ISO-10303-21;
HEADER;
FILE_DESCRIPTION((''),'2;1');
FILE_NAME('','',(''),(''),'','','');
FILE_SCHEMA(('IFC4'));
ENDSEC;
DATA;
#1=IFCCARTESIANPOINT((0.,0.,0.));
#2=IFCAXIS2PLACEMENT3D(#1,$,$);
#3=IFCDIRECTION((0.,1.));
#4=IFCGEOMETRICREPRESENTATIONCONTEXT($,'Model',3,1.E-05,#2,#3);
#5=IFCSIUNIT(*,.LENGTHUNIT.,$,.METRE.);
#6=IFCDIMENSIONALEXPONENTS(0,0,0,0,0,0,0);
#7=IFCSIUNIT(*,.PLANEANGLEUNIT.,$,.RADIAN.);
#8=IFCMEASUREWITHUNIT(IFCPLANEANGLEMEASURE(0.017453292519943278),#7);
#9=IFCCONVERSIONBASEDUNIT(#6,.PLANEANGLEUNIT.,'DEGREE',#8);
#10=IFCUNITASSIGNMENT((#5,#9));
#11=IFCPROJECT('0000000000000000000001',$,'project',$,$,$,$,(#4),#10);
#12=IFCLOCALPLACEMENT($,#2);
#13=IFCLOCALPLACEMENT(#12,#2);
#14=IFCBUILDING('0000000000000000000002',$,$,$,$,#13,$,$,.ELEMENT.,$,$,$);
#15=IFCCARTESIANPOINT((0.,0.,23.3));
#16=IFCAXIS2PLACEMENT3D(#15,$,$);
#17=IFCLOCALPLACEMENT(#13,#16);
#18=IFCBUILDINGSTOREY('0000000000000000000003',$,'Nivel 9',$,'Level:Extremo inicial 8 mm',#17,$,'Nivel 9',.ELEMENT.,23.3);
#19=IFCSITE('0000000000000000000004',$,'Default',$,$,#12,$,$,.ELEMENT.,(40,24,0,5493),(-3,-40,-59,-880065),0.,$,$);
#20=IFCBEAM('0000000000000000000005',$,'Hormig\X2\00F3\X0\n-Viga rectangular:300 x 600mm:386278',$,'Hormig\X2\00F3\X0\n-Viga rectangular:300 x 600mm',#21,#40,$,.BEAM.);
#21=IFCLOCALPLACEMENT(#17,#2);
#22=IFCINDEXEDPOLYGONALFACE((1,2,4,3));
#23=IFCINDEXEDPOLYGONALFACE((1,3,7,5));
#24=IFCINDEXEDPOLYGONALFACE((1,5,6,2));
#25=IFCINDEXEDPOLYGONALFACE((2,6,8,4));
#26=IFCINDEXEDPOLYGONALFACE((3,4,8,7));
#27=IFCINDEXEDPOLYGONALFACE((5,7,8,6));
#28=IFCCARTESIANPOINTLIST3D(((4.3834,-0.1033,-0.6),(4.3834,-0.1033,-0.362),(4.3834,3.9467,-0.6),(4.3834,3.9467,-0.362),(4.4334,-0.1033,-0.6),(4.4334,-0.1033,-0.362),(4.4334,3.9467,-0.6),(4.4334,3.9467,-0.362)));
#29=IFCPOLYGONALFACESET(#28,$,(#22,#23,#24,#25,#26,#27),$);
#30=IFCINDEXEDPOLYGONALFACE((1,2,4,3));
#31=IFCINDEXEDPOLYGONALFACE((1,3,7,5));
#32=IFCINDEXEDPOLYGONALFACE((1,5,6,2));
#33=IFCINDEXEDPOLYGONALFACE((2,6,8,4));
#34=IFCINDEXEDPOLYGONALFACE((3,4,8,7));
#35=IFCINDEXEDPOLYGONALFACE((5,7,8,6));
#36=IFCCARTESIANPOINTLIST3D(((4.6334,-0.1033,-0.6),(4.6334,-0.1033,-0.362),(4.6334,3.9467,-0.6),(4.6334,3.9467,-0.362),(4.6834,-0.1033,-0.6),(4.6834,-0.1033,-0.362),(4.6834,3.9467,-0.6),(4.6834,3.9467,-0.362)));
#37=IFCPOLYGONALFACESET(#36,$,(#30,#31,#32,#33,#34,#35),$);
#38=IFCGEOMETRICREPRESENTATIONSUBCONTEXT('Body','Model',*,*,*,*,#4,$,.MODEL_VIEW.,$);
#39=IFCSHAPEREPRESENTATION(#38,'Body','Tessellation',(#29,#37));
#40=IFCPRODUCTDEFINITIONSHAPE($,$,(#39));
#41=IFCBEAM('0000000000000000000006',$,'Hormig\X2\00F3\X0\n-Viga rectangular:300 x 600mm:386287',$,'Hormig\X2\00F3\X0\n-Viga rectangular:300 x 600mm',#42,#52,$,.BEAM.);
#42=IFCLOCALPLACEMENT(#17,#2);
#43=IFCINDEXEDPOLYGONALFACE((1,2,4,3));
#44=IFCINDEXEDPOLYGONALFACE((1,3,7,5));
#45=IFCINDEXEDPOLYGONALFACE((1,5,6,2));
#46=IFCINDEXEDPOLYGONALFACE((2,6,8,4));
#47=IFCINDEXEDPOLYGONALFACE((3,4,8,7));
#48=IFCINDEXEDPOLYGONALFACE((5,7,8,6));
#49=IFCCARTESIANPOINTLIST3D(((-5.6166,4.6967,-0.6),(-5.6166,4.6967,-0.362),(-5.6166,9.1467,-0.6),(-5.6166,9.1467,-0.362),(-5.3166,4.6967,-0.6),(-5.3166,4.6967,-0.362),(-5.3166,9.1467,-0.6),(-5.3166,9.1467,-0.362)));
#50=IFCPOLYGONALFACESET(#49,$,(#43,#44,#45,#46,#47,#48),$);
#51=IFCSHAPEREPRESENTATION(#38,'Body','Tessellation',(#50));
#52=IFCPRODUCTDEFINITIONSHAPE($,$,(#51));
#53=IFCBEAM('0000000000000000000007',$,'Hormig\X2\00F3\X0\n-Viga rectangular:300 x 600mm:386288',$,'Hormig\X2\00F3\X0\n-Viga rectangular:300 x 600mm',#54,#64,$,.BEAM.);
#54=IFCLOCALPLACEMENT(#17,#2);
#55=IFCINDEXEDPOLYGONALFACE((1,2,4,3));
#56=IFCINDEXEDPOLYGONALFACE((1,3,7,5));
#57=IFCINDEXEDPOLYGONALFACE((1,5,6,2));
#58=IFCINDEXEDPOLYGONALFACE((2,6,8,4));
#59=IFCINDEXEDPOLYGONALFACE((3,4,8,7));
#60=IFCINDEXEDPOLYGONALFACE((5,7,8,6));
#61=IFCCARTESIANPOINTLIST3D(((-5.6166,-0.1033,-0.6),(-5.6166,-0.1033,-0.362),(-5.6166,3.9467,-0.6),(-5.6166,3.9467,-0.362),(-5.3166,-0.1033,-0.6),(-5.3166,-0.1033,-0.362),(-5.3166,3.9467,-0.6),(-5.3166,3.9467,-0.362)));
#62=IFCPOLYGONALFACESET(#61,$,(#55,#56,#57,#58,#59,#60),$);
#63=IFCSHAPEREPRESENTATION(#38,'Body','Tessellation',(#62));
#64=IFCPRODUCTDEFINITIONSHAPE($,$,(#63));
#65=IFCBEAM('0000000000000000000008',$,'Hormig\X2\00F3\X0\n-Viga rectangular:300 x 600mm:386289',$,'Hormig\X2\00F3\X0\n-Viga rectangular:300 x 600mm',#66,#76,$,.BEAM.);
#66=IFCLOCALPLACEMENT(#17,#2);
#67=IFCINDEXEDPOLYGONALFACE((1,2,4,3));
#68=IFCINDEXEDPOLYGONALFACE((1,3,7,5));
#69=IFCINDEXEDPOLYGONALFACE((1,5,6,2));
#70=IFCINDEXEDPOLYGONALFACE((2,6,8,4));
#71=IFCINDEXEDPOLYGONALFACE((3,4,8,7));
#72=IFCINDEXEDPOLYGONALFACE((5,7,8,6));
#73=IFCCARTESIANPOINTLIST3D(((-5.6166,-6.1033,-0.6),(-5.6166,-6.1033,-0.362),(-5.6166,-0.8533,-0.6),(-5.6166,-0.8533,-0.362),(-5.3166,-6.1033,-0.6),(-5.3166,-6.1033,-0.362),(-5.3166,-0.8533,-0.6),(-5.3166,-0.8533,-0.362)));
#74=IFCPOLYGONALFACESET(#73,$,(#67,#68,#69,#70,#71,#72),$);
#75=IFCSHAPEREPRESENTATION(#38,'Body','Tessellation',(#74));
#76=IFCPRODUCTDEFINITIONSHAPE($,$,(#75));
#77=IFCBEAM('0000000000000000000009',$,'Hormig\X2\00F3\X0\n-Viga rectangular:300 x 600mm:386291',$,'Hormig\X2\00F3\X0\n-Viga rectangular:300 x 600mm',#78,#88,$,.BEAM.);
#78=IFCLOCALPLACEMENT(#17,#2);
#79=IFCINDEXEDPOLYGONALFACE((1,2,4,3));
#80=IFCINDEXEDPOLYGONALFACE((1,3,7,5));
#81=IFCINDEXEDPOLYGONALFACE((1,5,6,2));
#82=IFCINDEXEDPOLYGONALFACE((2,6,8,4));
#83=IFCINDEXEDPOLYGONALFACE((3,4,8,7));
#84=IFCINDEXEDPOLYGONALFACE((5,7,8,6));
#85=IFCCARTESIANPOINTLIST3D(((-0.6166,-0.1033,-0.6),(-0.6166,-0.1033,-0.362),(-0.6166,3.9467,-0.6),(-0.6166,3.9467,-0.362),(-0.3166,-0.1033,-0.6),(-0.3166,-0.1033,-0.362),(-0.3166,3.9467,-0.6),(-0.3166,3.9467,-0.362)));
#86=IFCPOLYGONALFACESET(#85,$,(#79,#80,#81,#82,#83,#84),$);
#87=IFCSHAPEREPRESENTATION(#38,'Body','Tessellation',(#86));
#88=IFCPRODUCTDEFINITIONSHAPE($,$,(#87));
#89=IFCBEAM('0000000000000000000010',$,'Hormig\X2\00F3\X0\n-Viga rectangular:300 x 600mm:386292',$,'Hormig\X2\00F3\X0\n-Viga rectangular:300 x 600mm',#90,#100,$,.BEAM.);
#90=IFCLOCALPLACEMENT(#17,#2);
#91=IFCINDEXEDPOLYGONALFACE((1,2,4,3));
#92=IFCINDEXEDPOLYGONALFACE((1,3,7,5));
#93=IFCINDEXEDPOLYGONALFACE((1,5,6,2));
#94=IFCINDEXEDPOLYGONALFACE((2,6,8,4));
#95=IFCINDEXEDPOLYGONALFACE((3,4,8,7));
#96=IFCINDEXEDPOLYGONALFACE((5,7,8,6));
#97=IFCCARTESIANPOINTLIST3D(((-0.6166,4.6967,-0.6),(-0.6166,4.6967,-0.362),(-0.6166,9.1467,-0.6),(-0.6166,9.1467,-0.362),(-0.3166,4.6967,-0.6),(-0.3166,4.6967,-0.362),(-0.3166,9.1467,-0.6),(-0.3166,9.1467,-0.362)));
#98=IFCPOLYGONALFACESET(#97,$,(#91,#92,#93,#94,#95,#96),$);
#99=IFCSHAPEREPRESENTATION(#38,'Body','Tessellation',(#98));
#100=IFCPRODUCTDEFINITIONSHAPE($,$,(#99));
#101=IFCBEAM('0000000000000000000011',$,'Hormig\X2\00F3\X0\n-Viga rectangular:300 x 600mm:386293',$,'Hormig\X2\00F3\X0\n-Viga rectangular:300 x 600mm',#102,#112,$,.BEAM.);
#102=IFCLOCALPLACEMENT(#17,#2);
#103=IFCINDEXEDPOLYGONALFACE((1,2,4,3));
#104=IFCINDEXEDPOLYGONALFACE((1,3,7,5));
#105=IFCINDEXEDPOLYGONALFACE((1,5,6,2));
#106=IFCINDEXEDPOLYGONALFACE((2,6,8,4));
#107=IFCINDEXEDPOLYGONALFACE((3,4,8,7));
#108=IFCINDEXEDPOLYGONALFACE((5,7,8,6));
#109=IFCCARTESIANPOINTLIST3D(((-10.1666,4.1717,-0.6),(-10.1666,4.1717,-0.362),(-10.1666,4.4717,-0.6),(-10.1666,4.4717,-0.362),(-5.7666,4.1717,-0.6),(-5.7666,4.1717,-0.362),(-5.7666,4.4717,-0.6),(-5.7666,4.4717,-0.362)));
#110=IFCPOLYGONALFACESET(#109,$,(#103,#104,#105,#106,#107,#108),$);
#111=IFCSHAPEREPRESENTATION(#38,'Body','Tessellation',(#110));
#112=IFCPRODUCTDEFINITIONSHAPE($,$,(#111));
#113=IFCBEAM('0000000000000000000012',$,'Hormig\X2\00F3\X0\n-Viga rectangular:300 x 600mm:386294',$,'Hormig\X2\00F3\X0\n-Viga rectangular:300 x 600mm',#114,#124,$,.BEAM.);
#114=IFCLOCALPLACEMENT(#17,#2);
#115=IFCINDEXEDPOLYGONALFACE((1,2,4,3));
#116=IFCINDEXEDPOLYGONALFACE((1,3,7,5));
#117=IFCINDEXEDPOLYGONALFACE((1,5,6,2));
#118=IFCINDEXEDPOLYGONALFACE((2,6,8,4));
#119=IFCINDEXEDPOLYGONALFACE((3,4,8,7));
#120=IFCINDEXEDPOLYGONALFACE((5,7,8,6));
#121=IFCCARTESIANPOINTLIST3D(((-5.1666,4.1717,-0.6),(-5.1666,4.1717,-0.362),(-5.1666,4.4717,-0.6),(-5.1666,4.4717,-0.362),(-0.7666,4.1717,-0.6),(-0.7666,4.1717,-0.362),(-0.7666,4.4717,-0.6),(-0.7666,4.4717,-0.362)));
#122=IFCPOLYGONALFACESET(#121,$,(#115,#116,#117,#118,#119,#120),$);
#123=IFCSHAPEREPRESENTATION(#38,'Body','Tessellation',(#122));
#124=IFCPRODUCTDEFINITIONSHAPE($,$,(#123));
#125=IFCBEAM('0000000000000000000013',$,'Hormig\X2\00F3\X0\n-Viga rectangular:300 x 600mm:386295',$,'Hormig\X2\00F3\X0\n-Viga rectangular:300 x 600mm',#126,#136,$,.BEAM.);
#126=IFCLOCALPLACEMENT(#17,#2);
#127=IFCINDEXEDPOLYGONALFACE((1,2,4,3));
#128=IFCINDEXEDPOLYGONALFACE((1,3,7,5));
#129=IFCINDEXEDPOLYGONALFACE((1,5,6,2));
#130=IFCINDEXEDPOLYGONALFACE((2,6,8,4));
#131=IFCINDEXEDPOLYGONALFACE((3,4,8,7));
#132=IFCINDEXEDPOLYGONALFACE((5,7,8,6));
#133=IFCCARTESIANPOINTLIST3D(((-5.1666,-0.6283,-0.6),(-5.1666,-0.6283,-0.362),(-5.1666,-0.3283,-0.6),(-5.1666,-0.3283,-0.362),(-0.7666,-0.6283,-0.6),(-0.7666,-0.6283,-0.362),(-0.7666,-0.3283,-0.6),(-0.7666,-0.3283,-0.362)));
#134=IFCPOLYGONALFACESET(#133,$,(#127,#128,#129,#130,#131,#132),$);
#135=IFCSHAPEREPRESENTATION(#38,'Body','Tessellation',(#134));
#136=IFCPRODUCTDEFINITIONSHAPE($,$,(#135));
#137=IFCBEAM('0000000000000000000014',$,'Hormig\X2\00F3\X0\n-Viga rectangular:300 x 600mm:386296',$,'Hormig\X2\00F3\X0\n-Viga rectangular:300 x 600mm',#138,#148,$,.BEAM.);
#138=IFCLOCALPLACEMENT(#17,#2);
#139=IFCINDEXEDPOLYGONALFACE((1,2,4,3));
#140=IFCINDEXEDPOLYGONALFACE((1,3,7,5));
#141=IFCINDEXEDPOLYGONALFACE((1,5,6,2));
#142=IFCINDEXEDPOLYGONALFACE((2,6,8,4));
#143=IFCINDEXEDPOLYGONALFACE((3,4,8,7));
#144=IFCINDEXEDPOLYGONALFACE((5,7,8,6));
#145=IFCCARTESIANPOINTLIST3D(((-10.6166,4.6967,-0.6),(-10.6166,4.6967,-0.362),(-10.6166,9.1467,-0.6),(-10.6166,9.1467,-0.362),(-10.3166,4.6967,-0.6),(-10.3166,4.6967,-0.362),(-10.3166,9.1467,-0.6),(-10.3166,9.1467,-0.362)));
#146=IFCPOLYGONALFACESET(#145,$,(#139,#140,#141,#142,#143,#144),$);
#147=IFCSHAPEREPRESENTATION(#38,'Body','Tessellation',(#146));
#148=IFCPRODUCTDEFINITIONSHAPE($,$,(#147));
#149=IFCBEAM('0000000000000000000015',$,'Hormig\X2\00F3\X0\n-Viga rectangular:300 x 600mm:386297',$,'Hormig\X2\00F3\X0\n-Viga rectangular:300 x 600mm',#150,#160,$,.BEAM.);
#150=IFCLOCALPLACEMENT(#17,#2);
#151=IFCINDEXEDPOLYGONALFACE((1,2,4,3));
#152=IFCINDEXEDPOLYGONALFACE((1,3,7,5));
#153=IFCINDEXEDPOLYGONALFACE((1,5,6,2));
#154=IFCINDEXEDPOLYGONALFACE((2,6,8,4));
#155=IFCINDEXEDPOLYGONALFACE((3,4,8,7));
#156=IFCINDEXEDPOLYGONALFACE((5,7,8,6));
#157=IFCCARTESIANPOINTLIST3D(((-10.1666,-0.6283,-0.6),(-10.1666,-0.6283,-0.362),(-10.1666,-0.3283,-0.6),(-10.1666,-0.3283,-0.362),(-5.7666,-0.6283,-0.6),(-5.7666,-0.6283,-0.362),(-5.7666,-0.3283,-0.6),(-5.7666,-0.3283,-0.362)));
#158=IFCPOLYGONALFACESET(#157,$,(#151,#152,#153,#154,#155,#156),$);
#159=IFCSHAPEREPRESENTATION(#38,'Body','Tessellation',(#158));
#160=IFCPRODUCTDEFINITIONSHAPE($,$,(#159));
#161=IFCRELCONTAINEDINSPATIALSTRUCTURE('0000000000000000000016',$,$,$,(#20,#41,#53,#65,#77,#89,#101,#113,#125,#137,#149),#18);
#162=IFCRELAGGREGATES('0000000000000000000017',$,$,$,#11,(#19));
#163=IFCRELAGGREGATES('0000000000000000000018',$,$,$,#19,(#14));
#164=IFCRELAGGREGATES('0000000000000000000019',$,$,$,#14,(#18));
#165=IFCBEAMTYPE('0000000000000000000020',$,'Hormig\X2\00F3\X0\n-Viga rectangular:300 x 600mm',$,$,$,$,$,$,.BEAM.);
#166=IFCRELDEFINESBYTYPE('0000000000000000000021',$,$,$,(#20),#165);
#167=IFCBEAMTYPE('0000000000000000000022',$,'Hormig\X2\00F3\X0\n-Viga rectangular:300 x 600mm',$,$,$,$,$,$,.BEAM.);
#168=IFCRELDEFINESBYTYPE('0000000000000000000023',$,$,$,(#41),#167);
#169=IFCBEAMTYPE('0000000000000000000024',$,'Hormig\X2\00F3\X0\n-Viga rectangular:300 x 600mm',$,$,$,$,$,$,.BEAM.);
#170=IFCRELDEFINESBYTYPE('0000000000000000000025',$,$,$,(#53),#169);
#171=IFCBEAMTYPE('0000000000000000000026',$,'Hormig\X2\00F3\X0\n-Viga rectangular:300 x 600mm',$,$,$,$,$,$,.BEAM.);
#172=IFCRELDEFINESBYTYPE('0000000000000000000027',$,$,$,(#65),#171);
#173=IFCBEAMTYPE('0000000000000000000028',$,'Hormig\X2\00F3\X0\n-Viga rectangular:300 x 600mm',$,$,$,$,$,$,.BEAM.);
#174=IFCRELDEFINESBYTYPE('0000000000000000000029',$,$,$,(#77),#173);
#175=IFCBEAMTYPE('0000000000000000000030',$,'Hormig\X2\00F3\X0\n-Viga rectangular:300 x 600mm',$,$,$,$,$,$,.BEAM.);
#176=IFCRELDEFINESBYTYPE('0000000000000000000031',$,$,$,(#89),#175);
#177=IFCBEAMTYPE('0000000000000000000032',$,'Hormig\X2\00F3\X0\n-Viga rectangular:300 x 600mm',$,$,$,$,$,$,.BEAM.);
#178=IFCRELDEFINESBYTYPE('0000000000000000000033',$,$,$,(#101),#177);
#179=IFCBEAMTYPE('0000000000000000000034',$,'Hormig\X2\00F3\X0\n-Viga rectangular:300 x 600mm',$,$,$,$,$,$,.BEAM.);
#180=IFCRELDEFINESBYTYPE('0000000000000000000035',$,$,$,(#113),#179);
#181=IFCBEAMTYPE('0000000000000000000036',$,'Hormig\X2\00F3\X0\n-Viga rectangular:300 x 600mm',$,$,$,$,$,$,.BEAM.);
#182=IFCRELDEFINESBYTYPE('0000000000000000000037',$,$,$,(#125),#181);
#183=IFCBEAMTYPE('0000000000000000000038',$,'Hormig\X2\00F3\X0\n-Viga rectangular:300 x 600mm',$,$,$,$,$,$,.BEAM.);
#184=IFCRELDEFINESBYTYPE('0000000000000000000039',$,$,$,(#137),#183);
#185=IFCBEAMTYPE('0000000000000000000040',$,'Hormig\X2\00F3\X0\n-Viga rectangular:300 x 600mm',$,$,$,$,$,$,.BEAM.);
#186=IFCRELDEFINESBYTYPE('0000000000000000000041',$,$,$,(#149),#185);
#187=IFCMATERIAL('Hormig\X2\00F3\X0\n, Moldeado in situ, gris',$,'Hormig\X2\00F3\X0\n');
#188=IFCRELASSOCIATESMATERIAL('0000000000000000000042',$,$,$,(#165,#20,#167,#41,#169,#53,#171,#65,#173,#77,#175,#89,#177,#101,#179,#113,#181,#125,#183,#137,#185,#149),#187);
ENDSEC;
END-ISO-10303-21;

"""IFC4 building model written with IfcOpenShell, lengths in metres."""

from ifc_helpers import new_model, entity, si_unit, converted_unit, direction, frame, origin, place, context, subcontext, project, spatial, indexed_curve, outline, extrude, source, transform, mapped, material, type_object, type_shapes, element, save


model = new_model("IFC4")

# Units and contexts
model_context = context("Model", 3, precision=1e-05, world=origin(), true_north=direction((0.0, 1.0)))
body_context = subcontext(model_context, "Body", "Model", "MODEL_VIEW")
ifc_project = project(units=[si_unit("LENGTHUNIT", "METRE"), converted_unit("PLANEANGLEUNIT", "DEGREE", entity("IfcPlaneAngleMeasure", 0.017453292519943278), si_unit("PLANEANGLEUNIT", "RADIAN"), dimensions=[0, 0, 0, 0, 0, 0, 0])], contexts=[model_context])

# Site, building, storey
site_placement = place(None, origin())
site = spatial("IfcSite", under=ifc_project, at=site_placement, Name="Default", CompositionType="ELEMENT", RefLatitude=(40, 24, 0, 5493), RefLongitude=(-3, -40, -59, -880065), RefElevation=0.0)
building_placement = place(site_placement, origin())
building = spatial("IfcBuilding", under=site, at=building_placement, CompositionType="ELEMENT")
storey_placement = place(building_placement, frame((0.0, 0.0, 23.3)))
storey = spatial("IfcBuildingStorey", under=building, at=storey_placement, Name="Nivel 9", ObjectType="Level:Extremo inicial 8 mm", LongName="Nivel 9", CompositionType="ELEMENT", Elevation=23.3)

# Shared definitions
ifc_material_1 = material(Name="Hormigón, Moldeado in situ, gris", Category="Hormigón")

# Beams
beam_type_1 = type_object("IfcBeamType", Name="Hormigón-Viga rectangular:300 x 600mm", PredefinedType="BEAM", material=ifc_material_1)
shared_shape_1 = source(origin(), body_context, "Body", "SweptSolid", [
    extrude(outline(indexed_curve([(-0.025, -0.119), (0.025, -0.119), (0.025, 0.119), (-0.025, 0.119), (-0.025, -0.119)], self_intersect=False)), frame((4.4084, 3.9467, 22.819), z_axis=(0.0, -1.0, 0.0), x_axis=(-1.0, 0.0, 0.0)), (0.0, 0.0, 1.0), 4.05),
    extrude(outline(indexed_curve([(-0.025, -0.119), (0.025, -0.119), (0.025, 0.119), (-0.025, 0.119), (-0.025, -0.119)], self_intersect=False)), frame((4.6584, 3.9467, 22.819), z_axis=(0.0, -1.0, 0.0), x_axis=(-1.0, 0.0, 0.0)), (0.0, 0.0, 1.0), 4.05),
])
type_shapes(beam_type_1, [shared_shape_1])
beam_1_placement = place(storey_placement, frame((0.0, 0.0, -23.3)))
element("IfcBeam", 1, at=beam_1_placement, inside=storey, type_object=beam_type_1, material=ifc_material_1, Name="Hormigón-Viga rectangular:300 x 600mm:386278", ObjectType="Hormigón-Viga rectangular:300 x 600mm", PredefinedType="BEAM", context=body_context, shape_type="MappedRepresentation", body=[
    mapped(shared_shape_1, transform((0.0, 0.0, 0.0), scale=1.0)),
])
beam_type_2 = type_object("IfcBeamType", Name="Hormigón-Viga rectangular:300 x 600mm", PredefinedType="BEAM", material=ifc_material_1)
shared_shape_2 = source(origin(), body_context, "Body", "SweptSolid", [
    extrude(outline(indexed_curve([(-0.15, -0.119), (0.15, -0.119), (0.15, 0.119), (-0.15, 0.119), (-0.15, -0.119)], self_intersect=False)), frame((-5.4666, 9.1467, 22.819), z_axis=(0.0, -1.0, 0.0), x_axis=(-1.0, 0.0, 0.0)), (0.0, 0.0, 1.0), 4.45),
])
type_shapes(beam_type_2, [shared_shape_2])
beam_2_placement = place(storey_placement, frame((0.0, 0.0, -23.3)))
element("IfcBeam", 2, at=beam_2_placement, inside=storey, type_object=beam_type_2, material=ifc_material_1, Name="Hormigón-Viga rectangular:300 x 600mm:386287", ObjectType="Hormigón-Viga rectangular:300 x 600mm", PredefinedType="BEAM", context=body_context, shape_type="MappedRepresentation", body=[
    mapped(shared_shape_2, transform((0.0, 0.0, 0.0), scale=1.0)),
])
beam_type_3 = type_object("IfcBeamType", Name="Hormigón-Viga rectangular:300 x 600mm", PredefinedType="BEAM", material=ifc_material_1)
shared_shape_3 = source(origin(), body_context, "Body", "SweptSolid", [
    extrude(outline(indexed_curve([(-0.15, -0.119), (0.15, -0.119), (0.15, 0.119), (-0.15, 0.119), (-0.15, -0.119)], self_intersect=False)), frame((-5.4666, 3.9467, 22.819), z_axis=(0.0, -1.0, 0.0), x_axis=(-1.0, 0.0, 0.0)), (0.0, 0.0, 1.0), 4.05),
])
type_shapes(beam_type_3, [shared_shape_3])
beam_3_placement = place(storey_placement, frame((0.0, 0.0, -23.3)))
element("IfcBeam", 3, at=beam_3_placement, inside=storey, type_object=beam_type_3, material=ifc_material_1, Name="Hormigón-Viga rectangular:300 x 600mm:386288", ObjectType="Hormigón-Viga rectangular:300 x 600mm", PredefinedType="BEAM", context=body_context, shape_type="MappedRepresentation", body=[
    mapped(shared_shape_3, transform((0.0, 0.0, 0.0), scale=1.0)),
])
beam_type_4 = type_object("IfcBeamType", Name="Hormigón-Viga rectangular:300 x 600mm", PredefinedType="BEAM", material=ifc_material_1)
shared_shape_4 = source(origin(), body_context, "Body", "SweptSolid", [
    extrude(outline(indexed_curve([(-0.15, -0.119), (0.15, -0.119), (0.15, 0.119), (-0.15, 0.119), (-0.15, -0.119)], self_intersect=False)), frame((-5.4666, -6.1033, 22.819), z_axis=(0.0, 1.0, 0.0), x_axis=(-1.0, 0.0, 0.0)), (0.0, 0.0, 1.0), 5.25),
])
type_shapes(beam_type_4, [shared_shape_4])
beam_4_placement = place(storey_placement, frame((0.0, 0.0, -23.3)))
element("IfcBeam", 4, at=beam_4_placement, inside=storey, type_object=beam_type_4, material=ifc_material_1, Name="Hormigón-Viga rectangular:300 x 600mm:386289", ObjectType="Hormigón-Viga rectangular:300 x 600mm", PredefinedType="BEAM", context=body_context, shape_type="MappedRepresentation", body=[
    mapped(shared_shape_4, transform((0.0, 0.0, 0.0), scale=1.0)),
])
beam_type_5 = type_object("IfcBeamType", Name="Hormigón-Viga rectangular:300 x 600mm", PredefinedType="BEAM", material=ifc_material_1)
shared_shape_5 = source(origin(), body_context, "Body", "SweptSolid", [
    extrude(outline(indexed_curve([(-0.15, -0.119), (0.15, -0.119), (0.15, 0.119), (-0.15, 0.119), (-0.15, -0.119)], self_intersect=False)), frame((-0.4666, -0.1033, 22.819), z_axis=(0.0, 1.0, 0.0), x_axis=(-1.0, 0.0, 0.0)), (0.0, 0.0, 1.0), 4.05),
])
type_shapes(beam_type_5, [shared_shape_5])
beam_5_placement = place(storey_placement, frame((0.0, 0.0, -23.3)))
element("IfcBeam", 5, at=beam_5_placement, inside=storey, type_object=beam_type_5, material=ifc_material_1, Name="Hormigón-Viga rectangular:300 x 600mm:386291", ObjectType="Hormigón-Viga rectangular:300 x 600mm", PredefinedType="BEAM", context=body_context, shape_type="MappedRepresentation", body=[
    mapped(shared_shape_5, transform((0.0, 0.0, 0.0), scale=1.0)),
])
beam_type_6 = type_object("IfcBeamType", Name="Hormigón-Viga rectangular:300 x 600mm", PredefinedType="BEAM", material=ifc_material_1)
shared_shape_6 = source(origin(), body_context, "Body", "SweptSolid", [
    extrude(outline(indexed_curve([(-0.15, -0.119), (0.15, -0.119), (0.15, 0.119), (-0.15, 0.119), (-0.15, -0.119)], self_intersect=False)), frame((-0.4666, 9.1467, 22.819), z_axis=(0.0, -1.0, 0.0), x_axis=(-1.0, 0.0, 0.0)), (0.0, 0.0, 1.0), 4.45),
])
type_shapes(beam_type_6, [shared_shape_6])
beam_6_placement = place(storey_placement, frame((0.0, 0.0, -23.3)))
element("IfcBeam", 6, at=beam_6_placement, inside=storey, type_object=beam_type_6, material=ifc_material_1, Name="Hormigón-Viga rectangular:300 x 600mm:386292", ObjectType="Hormigón-Viga rectangular:300 x 600mm", PredefinedType="BEAM", context=body_context, shape_type="MappedRepresentation", body=[
    mapped(shared_shape_6, transform((0.0, 0.0, 0.0), scale=1.0)),
])
beam_type_7 = type_object("IfcBeamType", Name="Hormigón-Viga rectangular:300 x 600mm", PredefinedType="BEAM", material=ifc_material_1)
shared_shape_7 = source(origin(), body_context, "Body", "SweptSolid", [
    extrude(outline(indexed_curve([(-0.119, -0.15), (0.119, -0.15), (0.119, 0.15), (-0.119, 0.15), (-0.119, -0.15)], self_intersect=False)), frame((-10.1666, 4.3217, 22.819), z_axis=(1.0, 0.0, 0.0), x_axis=(0.0, 0.0, -1.0)), (0.0, 0.0, 1.0), 4.4),
])
type_shapes(beam_type_7, [shared_shape_7])
beam_7_placement = place(storey_placement, frame((0.0, 0.0, -23.3)))
element("IfcBeam", 7, at=beam_7_placement, inside=storey, type_object=beam_type_7, material=ifc_material_1, Name="Hormigón-Viga rectangular:300 x 600mm:386293", ObjectType="Hormigón-Viga rectangular:300 x 600mm", PredefinedType="BEAM", context=body_context, shape_type="MappedRepresentation", body=[
    mapped(shared_shape_7, transform((0.0, 0.0, 0.0), scale=1.0)),
])
beam_type_8 = type_object("IfcBeamType", Name="Hormigón-Viga rectangular:300 x 600mm", PredefinedType="BEAM", material=ifc_material_1)
shared_shape_8 = source(origin(), body_context, "Body", "SweptSolid", [
    extrude(outline(indexed_curve([(-0.119, -0.15), (0.119, -0.15), (0.119, 0.15), (-0.119, 0.15), (-0.119, -0.15)], self_intersect=False)), frame((-5.1666, 4.3217, 22.819), z_axis=(1.0, 0.0, 0.0), x_axis=(0.0, 0.0, -1.0)), (0.0, 0.0, 1.0), 4.4),
])
type_shapes(beam_type_8, [shared_shape_8])
beam_8_placement = place(storey_placement, frame((0.0, 0.0, -23.3)))
element("IfcBeam", 8, at=beam_8_placement, inside=storey, type_object=beam_type_8, material=ifc_material_1, Name="Hormigón-Viga rectangular:300 x 600mm:386294", ObjectType="Hormigón-Viga rectangular:300 x 600mm", PredefinedType="BEAM", context=body_context, shape_type="MappedRepresentation", body=[
    mapped(shared_shape_8, transform((0.0, 0.0, 0.0), scale=1.0)),
])
beam_type_9 = type_object("IfcBeamType", Name="Hormigón-Viga rectangular:300 x 600mm", PredefinedType="BEAM", material=ifc_material_1)
shared_shape_9 = source(origin(), body_context, "Body", "SweptSolid", [
    extrude(outline(indexed_curve([(-0.119, -0.15), (0.119, -0.15), (0.119, 0.15), (-0.119, 0.15), (-0.119, -0.15)], self_intersect=False)), frame((-0.7666, -0.4783, 22.819), z_axis=(-1.0, 0.0, 0.0), x_axis=(0.0, 0.0, -1.0)), (0.0, 0.0, 1.0), 4.4),
])
type_shapes(beam_type_9, [shared_shape_9])
beam_9_placement = place(storey_placement, frame((0.0, 0.0, -23.3)))
element("IfcBeam", 9, at=beam_9_placement, inside=storey, type_object=beam_type_9, material=ifc_material_1, Name="Hormigón-Viga rectangular:300 x 600mm:386295", ObjectType="Hormigón-Viga rectangular:300 x 600mm", PredefinedType="BEAM", context=body_context, shape_type="MappedRepresentation", body=[
    mapped(shared_shape_9, transform((0.0, 0.0, 0.0), scale=1.0)),
])
beam_type_10 = type_object("IfcBeamType", Name="Hormigón-Viga rectangular:300 x 600mm", PredefinedType="BEAM", material=ifc_material_1)
shared_shape_10 = source(origin(), body_context, "Body", "SweptSolid", [
    extrude(outline(indexed_curve([(-0.15, -0.119), (0.15, -0.119), (0.15, 0.119), (-0.15, 0.119), (-0.15, -0.119)], self_intersect=False)), frame((-10.4666, 4.6967, 22.819), z_axis=(0.0, 1.0, 0.0), x_axis=(-1.0, 0.0, 0.0)), (0.0, 0.0, 1.0), 4.45),
])
type_shapes(beam_type_10, [shared_shape_10])
beam_10_placement = place(storey_placement, frame((0.0, 0.0, -23.3)))
element("IfcBeam", 10, at=beam_10_placement, inside=storey, type_object=beam_type_10, material=ifc_material_1, Name="Hormigón-Viga rectangular:300 x 600mm:386296", ObjectType="Hormigón-Viga rectangular:300 x 600mm", PredefinedType="BEAM", context=body_context, shape_type="MappedRepresentation", body=[
    mapped(shared_shape_10, transform((0.0, 0.0, 0.0), scale=1.0)),
])
beam_type_11 = type_object("IfcBeamType", Name="Hormigón-Viga rectangular:300 x 600mm", PredefinedType="BEAM", material=ifc_material_1)
shared_shape_11 = source(origin(), body_context, "Body", "SweptSolid", [
    extrude(outline(indexed_curve([(-0.119, -0.15), (0.119, -0.15), (0.119, 0.15), (-0.119, 0.15), (-0.119, -0.15)], self_intersect=False)), frame((-10.1666, -0.4783, 22.819), z_axis=(1.0, 0.0, 0.0), x_axis=(0.0, 0.0, -1.0)), (0.0, 0.0, 1.0), 4.4),
])
type_shapes(beam_type_11, [shared_shape_11])
beam_11_placement = place(storey_placement, frame((0.0, 0.0, -23.3)))
element("IfcBeam", 11, at=beam_11_placement, inside=storey, type_object=beam_type_11, material=ifc_material_1, Name="Hormigón-Viga rectangular:300 x 600mm:386297", ObjectType="Hormigón-Viga rectangular:300 x 600mm", PredefinedType="BEAM", context=body_context, shape_type="MappedRepresentation", body=[
    mapped(shared_shape_11, transform((0.0, 0.0, 0.0), scale=1.0)),
])

save(model, "model.ifc")
